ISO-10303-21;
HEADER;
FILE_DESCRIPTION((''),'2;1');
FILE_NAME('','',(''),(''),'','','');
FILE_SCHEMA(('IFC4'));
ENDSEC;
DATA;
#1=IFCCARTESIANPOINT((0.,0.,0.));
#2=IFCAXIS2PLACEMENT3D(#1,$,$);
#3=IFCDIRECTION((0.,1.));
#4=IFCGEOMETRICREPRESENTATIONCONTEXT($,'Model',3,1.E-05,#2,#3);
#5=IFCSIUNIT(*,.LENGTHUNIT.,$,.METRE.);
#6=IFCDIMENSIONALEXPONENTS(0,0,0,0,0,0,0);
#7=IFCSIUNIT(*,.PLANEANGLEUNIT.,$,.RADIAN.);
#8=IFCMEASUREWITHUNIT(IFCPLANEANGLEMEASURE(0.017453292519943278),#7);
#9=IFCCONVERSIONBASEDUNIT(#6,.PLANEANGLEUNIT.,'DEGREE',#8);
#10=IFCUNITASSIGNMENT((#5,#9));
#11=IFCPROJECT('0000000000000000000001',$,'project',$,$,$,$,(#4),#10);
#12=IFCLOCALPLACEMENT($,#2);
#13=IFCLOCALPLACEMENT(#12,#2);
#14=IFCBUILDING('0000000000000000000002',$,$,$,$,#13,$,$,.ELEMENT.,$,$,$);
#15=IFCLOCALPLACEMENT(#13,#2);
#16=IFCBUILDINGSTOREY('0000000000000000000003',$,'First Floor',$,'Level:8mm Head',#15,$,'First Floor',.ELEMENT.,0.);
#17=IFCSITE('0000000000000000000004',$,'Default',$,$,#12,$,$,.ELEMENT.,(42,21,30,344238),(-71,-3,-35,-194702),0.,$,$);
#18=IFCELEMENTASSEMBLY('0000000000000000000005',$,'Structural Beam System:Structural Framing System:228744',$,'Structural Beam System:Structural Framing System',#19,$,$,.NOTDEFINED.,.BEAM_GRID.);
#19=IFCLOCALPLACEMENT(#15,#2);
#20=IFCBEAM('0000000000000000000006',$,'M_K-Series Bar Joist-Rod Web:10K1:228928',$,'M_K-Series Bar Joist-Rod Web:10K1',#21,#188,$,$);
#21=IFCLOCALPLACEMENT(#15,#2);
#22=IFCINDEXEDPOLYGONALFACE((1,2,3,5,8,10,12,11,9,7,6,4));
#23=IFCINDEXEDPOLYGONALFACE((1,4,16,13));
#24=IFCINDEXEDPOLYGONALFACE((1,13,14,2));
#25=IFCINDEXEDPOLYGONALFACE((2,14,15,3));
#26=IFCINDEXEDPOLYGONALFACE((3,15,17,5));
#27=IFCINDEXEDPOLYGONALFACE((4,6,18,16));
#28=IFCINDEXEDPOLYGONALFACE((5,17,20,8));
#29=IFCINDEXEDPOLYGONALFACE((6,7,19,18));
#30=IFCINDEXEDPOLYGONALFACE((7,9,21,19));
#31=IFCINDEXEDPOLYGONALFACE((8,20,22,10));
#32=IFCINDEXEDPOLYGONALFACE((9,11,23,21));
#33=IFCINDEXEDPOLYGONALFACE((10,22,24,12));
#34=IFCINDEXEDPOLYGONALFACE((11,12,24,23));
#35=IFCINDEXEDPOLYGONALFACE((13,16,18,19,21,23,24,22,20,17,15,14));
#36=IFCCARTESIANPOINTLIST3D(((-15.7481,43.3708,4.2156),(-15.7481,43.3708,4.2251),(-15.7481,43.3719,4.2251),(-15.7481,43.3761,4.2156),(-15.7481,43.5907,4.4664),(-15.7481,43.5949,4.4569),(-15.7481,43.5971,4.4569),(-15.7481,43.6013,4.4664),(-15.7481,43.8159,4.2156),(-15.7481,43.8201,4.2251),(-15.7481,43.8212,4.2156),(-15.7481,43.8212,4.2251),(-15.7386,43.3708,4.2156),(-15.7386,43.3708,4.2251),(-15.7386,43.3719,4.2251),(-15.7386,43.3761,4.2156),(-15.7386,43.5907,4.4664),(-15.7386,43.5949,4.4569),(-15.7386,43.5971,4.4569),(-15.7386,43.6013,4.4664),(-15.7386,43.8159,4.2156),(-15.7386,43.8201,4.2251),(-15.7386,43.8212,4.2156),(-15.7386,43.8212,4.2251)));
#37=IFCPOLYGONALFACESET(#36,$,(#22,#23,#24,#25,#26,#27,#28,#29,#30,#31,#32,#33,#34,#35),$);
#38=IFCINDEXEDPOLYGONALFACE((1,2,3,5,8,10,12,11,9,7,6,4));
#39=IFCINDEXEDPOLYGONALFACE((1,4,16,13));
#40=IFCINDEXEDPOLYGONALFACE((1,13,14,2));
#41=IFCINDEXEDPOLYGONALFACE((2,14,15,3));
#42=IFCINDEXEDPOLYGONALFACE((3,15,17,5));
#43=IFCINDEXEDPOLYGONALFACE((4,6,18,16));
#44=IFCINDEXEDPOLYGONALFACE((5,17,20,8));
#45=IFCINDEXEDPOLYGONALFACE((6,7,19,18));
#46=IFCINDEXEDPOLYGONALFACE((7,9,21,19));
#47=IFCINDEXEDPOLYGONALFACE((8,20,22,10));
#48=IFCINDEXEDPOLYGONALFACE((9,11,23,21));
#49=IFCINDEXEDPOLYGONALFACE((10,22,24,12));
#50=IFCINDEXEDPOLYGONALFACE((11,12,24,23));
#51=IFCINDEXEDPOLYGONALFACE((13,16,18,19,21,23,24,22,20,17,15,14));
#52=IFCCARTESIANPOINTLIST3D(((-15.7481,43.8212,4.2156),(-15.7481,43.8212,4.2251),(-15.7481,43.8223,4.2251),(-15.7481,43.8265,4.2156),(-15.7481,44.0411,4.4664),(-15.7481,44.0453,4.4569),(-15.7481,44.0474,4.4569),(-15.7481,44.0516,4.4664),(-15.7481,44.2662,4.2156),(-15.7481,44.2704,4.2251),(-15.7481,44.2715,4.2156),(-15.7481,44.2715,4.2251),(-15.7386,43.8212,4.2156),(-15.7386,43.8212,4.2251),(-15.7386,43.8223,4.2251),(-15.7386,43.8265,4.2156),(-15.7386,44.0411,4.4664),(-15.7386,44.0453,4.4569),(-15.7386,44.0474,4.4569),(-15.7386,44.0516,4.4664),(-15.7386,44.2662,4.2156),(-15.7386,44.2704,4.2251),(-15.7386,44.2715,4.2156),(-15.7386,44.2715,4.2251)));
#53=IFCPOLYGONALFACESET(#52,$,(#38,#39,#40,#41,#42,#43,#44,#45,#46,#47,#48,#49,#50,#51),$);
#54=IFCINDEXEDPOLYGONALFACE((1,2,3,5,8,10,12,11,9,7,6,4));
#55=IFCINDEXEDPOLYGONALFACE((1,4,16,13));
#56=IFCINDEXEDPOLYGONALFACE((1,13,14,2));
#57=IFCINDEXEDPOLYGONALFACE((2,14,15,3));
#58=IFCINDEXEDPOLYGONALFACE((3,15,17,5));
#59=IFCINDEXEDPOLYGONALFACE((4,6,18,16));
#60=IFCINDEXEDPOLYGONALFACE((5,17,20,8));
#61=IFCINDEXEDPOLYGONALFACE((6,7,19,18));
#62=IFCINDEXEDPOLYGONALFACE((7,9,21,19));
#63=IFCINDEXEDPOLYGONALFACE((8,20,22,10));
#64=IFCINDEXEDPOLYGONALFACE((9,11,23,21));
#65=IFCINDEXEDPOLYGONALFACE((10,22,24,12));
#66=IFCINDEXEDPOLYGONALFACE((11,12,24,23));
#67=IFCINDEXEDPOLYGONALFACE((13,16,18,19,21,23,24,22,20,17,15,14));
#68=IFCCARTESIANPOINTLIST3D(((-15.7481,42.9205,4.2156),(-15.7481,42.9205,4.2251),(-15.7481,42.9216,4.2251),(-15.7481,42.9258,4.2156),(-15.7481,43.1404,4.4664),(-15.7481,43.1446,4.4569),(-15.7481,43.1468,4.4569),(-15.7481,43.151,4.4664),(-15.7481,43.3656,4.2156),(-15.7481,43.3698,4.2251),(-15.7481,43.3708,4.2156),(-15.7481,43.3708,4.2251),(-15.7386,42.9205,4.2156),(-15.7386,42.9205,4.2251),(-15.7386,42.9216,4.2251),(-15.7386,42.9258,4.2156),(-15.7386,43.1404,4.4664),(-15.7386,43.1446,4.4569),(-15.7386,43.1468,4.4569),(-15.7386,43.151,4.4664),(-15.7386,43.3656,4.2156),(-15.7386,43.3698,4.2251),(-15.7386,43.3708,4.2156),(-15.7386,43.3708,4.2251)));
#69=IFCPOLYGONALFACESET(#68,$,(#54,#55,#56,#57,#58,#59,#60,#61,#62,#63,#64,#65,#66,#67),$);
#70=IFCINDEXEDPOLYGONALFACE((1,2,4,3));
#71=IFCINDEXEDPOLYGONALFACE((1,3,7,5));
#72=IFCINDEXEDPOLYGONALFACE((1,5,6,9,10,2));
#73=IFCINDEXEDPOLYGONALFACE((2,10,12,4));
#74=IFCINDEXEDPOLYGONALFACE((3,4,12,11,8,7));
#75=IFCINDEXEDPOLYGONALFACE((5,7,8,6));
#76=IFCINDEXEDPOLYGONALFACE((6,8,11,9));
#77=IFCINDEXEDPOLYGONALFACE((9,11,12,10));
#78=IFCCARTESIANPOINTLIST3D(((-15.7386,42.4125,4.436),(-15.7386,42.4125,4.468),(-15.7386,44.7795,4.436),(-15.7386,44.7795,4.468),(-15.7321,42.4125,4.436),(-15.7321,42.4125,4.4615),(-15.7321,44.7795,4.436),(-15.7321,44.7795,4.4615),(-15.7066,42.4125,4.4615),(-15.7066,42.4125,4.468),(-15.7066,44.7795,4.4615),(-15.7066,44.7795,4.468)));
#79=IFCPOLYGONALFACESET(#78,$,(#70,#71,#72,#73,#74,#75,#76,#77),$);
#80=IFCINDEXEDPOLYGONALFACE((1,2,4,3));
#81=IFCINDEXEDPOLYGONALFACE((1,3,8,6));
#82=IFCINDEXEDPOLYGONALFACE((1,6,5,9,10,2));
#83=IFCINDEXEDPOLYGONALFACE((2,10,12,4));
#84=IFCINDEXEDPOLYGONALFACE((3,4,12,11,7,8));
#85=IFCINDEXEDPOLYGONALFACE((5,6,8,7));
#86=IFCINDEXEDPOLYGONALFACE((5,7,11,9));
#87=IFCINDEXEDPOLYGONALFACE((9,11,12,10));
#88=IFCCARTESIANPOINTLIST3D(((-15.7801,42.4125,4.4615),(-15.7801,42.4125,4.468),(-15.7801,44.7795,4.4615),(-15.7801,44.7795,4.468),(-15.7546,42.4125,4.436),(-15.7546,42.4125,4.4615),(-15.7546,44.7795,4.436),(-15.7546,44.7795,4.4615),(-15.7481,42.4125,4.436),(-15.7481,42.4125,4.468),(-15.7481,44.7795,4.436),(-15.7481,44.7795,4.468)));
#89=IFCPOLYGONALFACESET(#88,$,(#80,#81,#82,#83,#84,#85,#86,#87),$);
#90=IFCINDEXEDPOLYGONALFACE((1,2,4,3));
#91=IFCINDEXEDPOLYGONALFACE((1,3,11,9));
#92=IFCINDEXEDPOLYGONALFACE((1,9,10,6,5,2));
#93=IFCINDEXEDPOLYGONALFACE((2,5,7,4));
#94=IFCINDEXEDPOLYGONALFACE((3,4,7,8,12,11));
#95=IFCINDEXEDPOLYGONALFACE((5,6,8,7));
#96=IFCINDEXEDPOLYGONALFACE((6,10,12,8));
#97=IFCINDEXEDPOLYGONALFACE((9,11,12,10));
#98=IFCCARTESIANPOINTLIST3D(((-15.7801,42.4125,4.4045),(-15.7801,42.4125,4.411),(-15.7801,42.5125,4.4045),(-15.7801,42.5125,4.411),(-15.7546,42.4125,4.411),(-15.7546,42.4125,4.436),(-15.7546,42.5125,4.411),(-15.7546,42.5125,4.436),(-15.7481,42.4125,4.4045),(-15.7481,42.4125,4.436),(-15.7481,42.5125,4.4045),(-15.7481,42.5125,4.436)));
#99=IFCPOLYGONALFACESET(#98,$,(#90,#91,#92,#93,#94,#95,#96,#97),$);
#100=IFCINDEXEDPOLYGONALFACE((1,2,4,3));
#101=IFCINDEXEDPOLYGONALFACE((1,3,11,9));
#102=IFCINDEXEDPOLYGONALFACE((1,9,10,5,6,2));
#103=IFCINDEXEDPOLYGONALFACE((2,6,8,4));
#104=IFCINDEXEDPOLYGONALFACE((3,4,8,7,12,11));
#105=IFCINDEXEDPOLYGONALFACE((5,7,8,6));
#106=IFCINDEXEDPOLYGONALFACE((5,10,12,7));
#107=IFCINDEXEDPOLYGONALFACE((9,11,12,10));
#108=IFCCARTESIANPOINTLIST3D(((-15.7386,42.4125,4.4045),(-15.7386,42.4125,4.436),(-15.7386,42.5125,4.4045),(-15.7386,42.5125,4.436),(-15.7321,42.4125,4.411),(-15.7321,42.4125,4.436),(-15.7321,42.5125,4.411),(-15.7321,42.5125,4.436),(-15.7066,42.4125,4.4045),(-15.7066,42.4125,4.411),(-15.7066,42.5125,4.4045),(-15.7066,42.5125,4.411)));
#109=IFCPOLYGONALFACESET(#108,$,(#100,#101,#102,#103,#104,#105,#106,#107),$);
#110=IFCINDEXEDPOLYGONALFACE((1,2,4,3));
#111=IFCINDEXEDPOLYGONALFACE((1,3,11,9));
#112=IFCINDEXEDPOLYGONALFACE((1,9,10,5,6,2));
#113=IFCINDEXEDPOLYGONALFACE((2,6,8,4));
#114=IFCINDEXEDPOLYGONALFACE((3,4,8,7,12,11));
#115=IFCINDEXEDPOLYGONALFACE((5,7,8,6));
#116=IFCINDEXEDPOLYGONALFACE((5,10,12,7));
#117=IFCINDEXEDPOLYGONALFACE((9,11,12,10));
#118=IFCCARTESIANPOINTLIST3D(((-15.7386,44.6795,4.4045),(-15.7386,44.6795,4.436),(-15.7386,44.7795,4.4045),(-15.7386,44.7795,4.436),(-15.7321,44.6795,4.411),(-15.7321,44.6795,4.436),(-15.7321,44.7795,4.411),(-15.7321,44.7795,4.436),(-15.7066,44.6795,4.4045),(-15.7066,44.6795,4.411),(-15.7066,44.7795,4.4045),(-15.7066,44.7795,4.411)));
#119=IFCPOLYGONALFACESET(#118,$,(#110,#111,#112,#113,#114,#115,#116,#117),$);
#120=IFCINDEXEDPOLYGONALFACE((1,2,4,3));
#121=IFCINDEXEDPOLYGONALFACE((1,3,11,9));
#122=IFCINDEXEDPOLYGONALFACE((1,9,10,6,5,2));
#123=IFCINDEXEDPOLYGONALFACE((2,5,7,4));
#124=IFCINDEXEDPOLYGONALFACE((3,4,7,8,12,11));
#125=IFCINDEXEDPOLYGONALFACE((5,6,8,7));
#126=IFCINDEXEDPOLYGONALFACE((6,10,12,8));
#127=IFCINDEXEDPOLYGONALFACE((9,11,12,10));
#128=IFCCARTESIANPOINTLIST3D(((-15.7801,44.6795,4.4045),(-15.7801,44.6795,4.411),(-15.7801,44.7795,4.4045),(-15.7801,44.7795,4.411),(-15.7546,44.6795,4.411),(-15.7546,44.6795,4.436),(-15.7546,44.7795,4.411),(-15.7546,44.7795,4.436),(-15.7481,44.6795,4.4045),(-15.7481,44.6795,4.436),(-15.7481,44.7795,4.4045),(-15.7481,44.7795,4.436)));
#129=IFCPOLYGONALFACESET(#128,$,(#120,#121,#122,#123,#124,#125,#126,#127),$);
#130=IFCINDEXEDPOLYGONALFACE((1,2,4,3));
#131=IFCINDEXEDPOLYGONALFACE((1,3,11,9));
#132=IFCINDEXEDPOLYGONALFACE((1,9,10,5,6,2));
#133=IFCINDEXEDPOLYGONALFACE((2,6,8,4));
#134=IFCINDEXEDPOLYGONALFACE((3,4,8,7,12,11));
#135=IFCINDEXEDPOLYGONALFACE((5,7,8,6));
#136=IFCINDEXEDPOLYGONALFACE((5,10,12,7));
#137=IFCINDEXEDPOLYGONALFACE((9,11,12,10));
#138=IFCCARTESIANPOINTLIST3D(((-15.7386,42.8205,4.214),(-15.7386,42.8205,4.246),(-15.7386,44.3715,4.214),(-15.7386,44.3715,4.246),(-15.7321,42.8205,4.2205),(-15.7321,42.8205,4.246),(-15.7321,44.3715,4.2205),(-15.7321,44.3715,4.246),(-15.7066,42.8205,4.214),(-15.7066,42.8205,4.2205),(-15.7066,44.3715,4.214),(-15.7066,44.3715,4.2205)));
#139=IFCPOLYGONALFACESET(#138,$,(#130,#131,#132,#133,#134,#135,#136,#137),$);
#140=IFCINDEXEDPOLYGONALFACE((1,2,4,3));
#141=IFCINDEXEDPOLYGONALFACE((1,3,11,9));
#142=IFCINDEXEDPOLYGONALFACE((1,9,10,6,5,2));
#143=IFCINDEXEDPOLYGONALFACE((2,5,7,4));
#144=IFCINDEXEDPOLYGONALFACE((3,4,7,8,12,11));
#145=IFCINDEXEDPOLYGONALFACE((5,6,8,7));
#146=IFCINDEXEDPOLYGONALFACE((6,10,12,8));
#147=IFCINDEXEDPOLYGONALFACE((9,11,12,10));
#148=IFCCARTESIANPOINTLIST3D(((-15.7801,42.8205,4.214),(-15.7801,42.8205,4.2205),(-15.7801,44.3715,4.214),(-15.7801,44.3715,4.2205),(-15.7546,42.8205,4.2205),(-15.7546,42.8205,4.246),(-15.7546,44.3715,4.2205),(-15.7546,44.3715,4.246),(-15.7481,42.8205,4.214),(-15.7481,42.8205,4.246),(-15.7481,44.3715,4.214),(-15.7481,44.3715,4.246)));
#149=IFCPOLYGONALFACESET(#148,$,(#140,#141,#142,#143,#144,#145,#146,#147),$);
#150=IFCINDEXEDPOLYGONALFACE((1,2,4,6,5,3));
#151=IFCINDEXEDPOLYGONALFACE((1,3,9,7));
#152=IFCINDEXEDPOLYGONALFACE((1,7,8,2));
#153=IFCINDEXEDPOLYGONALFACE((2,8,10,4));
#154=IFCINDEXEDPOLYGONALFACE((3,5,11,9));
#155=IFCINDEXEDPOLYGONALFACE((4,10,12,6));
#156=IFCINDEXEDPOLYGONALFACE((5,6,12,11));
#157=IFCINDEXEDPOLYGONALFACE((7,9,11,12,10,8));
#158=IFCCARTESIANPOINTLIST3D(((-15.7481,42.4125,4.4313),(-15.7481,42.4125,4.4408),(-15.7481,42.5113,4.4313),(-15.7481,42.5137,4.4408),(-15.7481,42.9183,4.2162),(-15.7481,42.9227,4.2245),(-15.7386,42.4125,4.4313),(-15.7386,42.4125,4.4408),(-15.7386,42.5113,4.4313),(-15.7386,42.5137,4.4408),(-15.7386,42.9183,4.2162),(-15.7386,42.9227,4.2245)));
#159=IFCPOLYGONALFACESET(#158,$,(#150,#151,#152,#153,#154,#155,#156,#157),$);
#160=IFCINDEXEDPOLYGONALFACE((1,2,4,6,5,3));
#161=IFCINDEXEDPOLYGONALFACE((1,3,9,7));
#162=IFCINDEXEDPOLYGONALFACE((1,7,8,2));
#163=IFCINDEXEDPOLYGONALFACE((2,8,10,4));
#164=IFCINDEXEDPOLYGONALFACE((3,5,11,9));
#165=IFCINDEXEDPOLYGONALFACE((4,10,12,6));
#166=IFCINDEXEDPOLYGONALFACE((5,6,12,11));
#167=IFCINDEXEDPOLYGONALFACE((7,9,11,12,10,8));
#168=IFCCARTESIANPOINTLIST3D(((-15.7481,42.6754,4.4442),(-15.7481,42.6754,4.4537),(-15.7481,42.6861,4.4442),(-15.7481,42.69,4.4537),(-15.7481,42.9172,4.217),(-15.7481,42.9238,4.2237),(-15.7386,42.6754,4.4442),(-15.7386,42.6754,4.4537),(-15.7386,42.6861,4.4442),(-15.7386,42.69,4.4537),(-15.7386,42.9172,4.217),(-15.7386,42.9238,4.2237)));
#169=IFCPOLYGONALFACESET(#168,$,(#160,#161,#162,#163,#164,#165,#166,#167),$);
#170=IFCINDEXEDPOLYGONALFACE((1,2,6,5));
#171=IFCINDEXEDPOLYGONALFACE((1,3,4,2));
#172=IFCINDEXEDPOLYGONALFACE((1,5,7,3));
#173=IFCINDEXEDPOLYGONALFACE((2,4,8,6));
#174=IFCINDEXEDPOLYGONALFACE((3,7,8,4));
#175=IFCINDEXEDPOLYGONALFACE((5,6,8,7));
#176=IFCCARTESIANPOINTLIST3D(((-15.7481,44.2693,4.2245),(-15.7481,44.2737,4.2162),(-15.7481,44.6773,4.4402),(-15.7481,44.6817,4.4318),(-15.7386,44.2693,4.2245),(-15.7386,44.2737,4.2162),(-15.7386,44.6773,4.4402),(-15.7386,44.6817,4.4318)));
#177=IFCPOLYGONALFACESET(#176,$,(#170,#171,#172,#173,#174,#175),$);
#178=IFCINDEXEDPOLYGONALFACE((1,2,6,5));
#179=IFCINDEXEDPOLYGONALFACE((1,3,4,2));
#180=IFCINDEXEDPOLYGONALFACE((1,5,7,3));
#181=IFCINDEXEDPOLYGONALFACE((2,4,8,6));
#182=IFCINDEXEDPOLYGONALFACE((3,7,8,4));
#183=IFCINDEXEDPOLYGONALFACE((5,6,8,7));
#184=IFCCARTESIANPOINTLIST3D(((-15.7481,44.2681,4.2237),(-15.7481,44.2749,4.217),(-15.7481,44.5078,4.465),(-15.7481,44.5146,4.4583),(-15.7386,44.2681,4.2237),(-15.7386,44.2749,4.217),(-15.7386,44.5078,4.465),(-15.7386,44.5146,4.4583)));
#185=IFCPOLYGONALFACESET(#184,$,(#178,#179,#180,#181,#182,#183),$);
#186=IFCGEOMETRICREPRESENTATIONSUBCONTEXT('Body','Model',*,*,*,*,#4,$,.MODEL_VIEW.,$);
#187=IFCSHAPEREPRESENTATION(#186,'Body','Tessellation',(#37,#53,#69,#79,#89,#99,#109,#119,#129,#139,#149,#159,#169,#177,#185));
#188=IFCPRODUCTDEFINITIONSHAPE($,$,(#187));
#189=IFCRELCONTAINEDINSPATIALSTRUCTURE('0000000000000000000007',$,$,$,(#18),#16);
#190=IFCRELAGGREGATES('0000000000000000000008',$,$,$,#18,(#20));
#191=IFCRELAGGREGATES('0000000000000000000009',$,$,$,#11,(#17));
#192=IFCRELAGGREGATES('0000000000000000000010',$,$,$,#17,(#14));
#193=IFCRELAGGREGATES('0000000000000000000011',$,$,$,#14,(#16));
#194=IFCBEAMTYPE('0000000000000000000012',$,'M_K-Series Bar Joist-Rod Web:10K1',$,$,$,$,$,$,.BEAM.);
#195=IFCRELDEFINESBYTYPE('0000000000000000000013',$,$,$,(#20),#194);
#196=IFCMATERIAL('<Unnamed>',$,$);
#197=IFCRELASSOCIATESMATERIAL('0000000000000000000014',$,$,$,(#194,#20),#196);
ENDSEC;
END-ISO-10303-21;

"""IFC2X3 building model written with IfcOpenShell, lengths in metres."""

from ifc_helpers import new_model, entity, si_unit, converted_unit, direction, frame, frame_2d, origin, place, context, subcontext, project, spatial, polyline, rectangle, outline, extrude, source, transform, mapped, material, type_object, type_shapes, element, aggregate, save


model = new_model("IFC2X3")

# Units and contexts
model_context = context("Model", 3, precision=1e-05, world=origin(), true_north=direction((0.0, 1.0)))
body_context = subcontext(model_context, "Body", "Model", "MODEL_VIEW")
ifc_project = project(units=[si_unit("LENGTHUNIT", "METRE"), converted_unit("PLANEANGLEUNIT", "DEGREE", entity("IfcPlaneAngleMeasure", 0.017453292519943278), si_unit("PLANEANGLEUNIT", "RADIAN"), dimensions=[0, 0, 0, 0, 0, 0, 0])], contexts=[model_context])

# Site, building, storey
site_placement = place(None, origin())
site = spatial("IfcSite", under=ifc_project, at=site_placement, Name="Default", CompositionType="ELEMENT", RefLatitude=(42, 21, 30, 344238), RefLongitude=(-71, -3, -35, -194702), RefElevation=0.0)
building_placement = place(site_placement, origin())
building = spatial("IfcBuilding", under=site, at=building_placement, CompositionType="ELEMENT")
storey_placement = place(building_placement, origin())
storey = spatial("IfcBuildingStorey", under=building, at=storey_placement, Name="First Floor", ObjectType="Level:8mm Head", LongName="First Floor", CompositionType="ELEMENT", Elevation=0.0)

# Shared definitions
ifc_material_1 = material(Name="<Unnamed>")

# Element assembly, beam
assembly_1_placement = place(storey_placement, origin())
assembly_1 = element("IfcElementAssembly", 1, at=assembly_1_placement, inside=storey, Name="Structural Beam System:Structural Framing System:228744", ObjectType="Structural Beam System:Structural Framing System", AssemblyPlace="NOTDEFINED", PredefinedType="BEAM_GRID")
beam_type_1 = type_object("IfcBeamType", Name="M_K-Series Bar Joist-Rod Web:10K1", PredefinedType="BEAM", material=ifc_material_1)
shared_shape_1 = source(origin(), body_context, "Body", "SweptSolid", [
    extrude(outline(polyline([(-0.2252, -0.0757), (-0.2252, -0.0852), (-0.2199, -0.0852), (-0.0011, 0.1561), (0.0011, 0.1561), (0.2199, -0.0852), (0.2252, -0.0852), (0.2252, -0.0757), (0.2241, -0.0757), (0.0053, 0.1656), (-0.0053, 0.1656), (-0.2241, -0.0757), (-0.2252, -0.0757)])), frame((0.0, -0.0047, -0.0402), z_axis=(0.0, -1.0, 0.0), x_axis=(1.0, 0.0, 0.0)), (0.0, 0.0, -1.0), 0.0095),
    extrude(outline(polyline([(-0.2252, -0.0757), (-0.2252, -0.0852), (-0.2199, -0.0852), (-0.0011, 0.1561), (0.0011, 0.1561), (0.2199, -0.0852), (0.2252, -0.0852), (0.2252, -0.0757), (0.2241, -0.0757), (0.0053, 0.1656), (-0.0053, 0.1656), (-0.2241, -0.0757), (-0.2252, -0.0757)])), frame((0.4503, -0.0047, -0.0402), z_axis=(0.0, -1.0, 0.0), x_axis=(1.0, 0.0, 0.0)), (0.0, 0.0, -1.0), 0.0095),
    extrude(outline(polyline([(-0.2252, -0.0757), (-0.2252, -0.0852), (-0.2199, -0.0852), (-0.0011, 0.1561), (0.0011, 0.1561), (0.2199, -0.0852), (0.2252, -0.0852), (0.2252, -0.0757), (0.2241, -0.0757), (0.0053, 0.1656), (-0.0053, 0.1656), (-0.2241, -0.0757), (-0.2252, -0.0757)])), frame((-0.4503, -0.0047, -0.0402), z_axis=(0.0, -1.0, 0.0), x_axis=(1.0, 0.0, 0.0)), (0.0, 0.0, -1.0), 0.0095),
    extrude(outline(polyline([(-0.0128, -0.0128), (0.0192, -0.0128), (0.0192, -0.0063), (-0.0063, -0.0063), (-0.0063, 0.0192), (-0.0128, 0.0192), (-0.0128, -0.0128)])), frame((-1.1835, -0.0176, 0.1142), z_axis=(1.0, 0.0, 0.0), x_axis=(0.0, -1.0, 0.0)), (0.0, 0.0, 1.0), 2.367),
    extrude(outline(polyline([(-0.0128, -0.0128), (0.0192, -0.0128), (0.0192, -0.0063), (-0.0063, -0.0063), (-0.0063, 0.0192), (-0.0128, 0.0192), (-0.0128, -0.0128)])), frame((-1.1835, 0.0176, 0.1142), z_axis=(1.0, 0.0, 0.0), x_axis=(0.0, 0.0, -1.0)), (0.0, 0.0, 1.0), 2.367),
    extrude(outline(polyline([(-0.0127, -0.0192), (-0.0062, -0.0192), (-0.0062, 0.0063), (0.0188, 0.0063), (0.0188, 0.0128), (-0.0127, 0.0128), (-0.0127, -0.0192)])), frame((-1.1835, 0.0176, 0.0762), z_axis=(1.0, 0.0, 0.0), x_axis=(0.0, 0.0, 1.0)), (0.0, 0.0, 1.0), 0.1),
    extrude(outline(polyline([(-0.0127, -0.0128), (0.0188, -0.0128), (0.0188, -0.0063), (-0.0062, -0.0063), (-0.0062, 0.0192), (-0.0127, 0.0192), (-0.0127, -0.0128)])), frame((-1.1835, -0.0176, 0.0762), z_axis=(1.0, 0.0, 0.0), x_axis=(0.0, 0.0, 1.0)), (0.0, 0.0, 1.0), 0.1),
    extrude(outline(polyline([(-0.0127, -0.0128), (0.0188, -0.0128), (0.0188, -0.0063), (-0.0062, -0.0063), (-0.0062, 0.0192), (-0.0127, 0.0192), (-0.0127, -0.0128)])), frame((1.0835, -0.0176, 0.0762), z_axis=(1.0, 0.0, 0.0), x_axis=(0.0, 0.0, 1.0)), (0.0, 0.0, 1.0), 0.1),
    extrude(outline(polyline([(-0.0128, -0.0127), (0.0192, -0.0127), (0.0192, -0.0062), (-0.0063, -0.0062), (-0.0063, 0.0188), (-0.0128, 0.0188), (-0.0128, -0.0127)])), frame((1.0835, 0.0176, 0.0762), z_axis=(1.0, 0.0, 0.0), x_axis=(0.0, 1.0, 0.0)), (0.0, 0.0, 1.0), 0.1),
    extrude(outline(polyline([(-0.0128, -0.0128), (0.0192, -0.0128), (0.0192, -0.0063), (-0.0063, -0.0063), (-0.0063, 0.0192), (-0.0128, 0.0192), (-0.0128, -0.0128)])), frame((-0.7755, -0.0176, -0.1142), z_axis=(1.0, 0.0, 0.0), x_axis=(0.0, 0.0, 1.0)), (0.0, 0.0, 1.0), 1.551),
    extrude(outline(polyline([(-0.0128, -0.0128), (0.0192, -0.0128), (0.0192, -0.0063), (-0.0063, -0.0063), (-0.0063, 0.0192), (-0.0128, 0.0192), (-0.0128, -0.0128)])), frame((-0.7755, 0.0176, -0.1142), z_axis=(1.0, 0.0, 0.0), x_axis=(0.0, 1.0, 0.0)), (0.0, 0.0, 1.0), 1.551),
    extrude(outline(polyline([(-0.3371, -0.0108), (-0.3371, -0.0203), (0.1255, -0.0203), (0.215, 0.027), (0.2105, 0.0354), (0.1232, -0.0108), (-0.3371, -0.0108)])), frame((-0.9808, -0.0048, 0.0231), z_axis=(0.0, -1.0, 0.0), x_axis=(-0.884101, 0.0, 0.467295)), (0.0, 0.0, -1.0), 0.0095),
    extrude(outline(polyline([(-0.0859, -0.0809), (-0.0713, -0.0809), (0.1625, 0.149), (0.1559, 0.1558), (-0.0752, -0.0714), (-0.0859, -0.0714), (-0.0859, -0.0809)])), frame((-0.8347, -0.0047, 0.0318), z_axis=(0.0, 1.0, 0.0), x_axis=(1.0, 0.0, 0.0)), (0.0, 0.0, 1.0), 0.0095),
    extrude(rectangle(XDim=0.0095, YDim=0.0095, at=frame_2d((0.0, 0.0), x_axis=(0.0, 1.0))), frame((0.6755, 0.0, -0.1206), z_axis=(0.884101, 0.0, 0.467295), x_axis=(0.0, 1.0, 0.0)), (0.0, 0.0, 1.0), 0.4615),
    extrude(rectangle(XDim=0.3401, YDim=0.0095, at=frame_2d((0.0, 0.0), x_axis=(1.0, 0.0))), frame((0.7953, -0.0047, 0.0), z_axis=(0.0, 1.0, 0.0), x_axis=(-0.704723, 0.0, -0.709483)), (0.0, 0.0, 1.0), 0.0095),
])
type_shapes(beam_type_1, [shared_shape_1])
beam_1_placement = place(assembly_1_placement, frame((-15.7433, 43.596, 4.341), z_axis=(0.0, 0.0, 1.0), x_axis=(0.0, 1.0, 0.0)))
beam_1 = element("IfcBeam", 2, at=beam_1_placement, type_object=beam_type_1, material=ifc_material_1, Name="M_K-Series Bar Joist-Rod Web:10K1:228928", ObjectType="M_K-Series Bar Joist-Rod Web:10K1", context=body_context, shape_type="MappedRepresentation", body=[
    mapped(shared_shape_1, transform((0.0, 0.0, 0.0), scale=1.0)),
])
aggregate(assembly_1, [beam_1])

save(model, "model.ifc")
